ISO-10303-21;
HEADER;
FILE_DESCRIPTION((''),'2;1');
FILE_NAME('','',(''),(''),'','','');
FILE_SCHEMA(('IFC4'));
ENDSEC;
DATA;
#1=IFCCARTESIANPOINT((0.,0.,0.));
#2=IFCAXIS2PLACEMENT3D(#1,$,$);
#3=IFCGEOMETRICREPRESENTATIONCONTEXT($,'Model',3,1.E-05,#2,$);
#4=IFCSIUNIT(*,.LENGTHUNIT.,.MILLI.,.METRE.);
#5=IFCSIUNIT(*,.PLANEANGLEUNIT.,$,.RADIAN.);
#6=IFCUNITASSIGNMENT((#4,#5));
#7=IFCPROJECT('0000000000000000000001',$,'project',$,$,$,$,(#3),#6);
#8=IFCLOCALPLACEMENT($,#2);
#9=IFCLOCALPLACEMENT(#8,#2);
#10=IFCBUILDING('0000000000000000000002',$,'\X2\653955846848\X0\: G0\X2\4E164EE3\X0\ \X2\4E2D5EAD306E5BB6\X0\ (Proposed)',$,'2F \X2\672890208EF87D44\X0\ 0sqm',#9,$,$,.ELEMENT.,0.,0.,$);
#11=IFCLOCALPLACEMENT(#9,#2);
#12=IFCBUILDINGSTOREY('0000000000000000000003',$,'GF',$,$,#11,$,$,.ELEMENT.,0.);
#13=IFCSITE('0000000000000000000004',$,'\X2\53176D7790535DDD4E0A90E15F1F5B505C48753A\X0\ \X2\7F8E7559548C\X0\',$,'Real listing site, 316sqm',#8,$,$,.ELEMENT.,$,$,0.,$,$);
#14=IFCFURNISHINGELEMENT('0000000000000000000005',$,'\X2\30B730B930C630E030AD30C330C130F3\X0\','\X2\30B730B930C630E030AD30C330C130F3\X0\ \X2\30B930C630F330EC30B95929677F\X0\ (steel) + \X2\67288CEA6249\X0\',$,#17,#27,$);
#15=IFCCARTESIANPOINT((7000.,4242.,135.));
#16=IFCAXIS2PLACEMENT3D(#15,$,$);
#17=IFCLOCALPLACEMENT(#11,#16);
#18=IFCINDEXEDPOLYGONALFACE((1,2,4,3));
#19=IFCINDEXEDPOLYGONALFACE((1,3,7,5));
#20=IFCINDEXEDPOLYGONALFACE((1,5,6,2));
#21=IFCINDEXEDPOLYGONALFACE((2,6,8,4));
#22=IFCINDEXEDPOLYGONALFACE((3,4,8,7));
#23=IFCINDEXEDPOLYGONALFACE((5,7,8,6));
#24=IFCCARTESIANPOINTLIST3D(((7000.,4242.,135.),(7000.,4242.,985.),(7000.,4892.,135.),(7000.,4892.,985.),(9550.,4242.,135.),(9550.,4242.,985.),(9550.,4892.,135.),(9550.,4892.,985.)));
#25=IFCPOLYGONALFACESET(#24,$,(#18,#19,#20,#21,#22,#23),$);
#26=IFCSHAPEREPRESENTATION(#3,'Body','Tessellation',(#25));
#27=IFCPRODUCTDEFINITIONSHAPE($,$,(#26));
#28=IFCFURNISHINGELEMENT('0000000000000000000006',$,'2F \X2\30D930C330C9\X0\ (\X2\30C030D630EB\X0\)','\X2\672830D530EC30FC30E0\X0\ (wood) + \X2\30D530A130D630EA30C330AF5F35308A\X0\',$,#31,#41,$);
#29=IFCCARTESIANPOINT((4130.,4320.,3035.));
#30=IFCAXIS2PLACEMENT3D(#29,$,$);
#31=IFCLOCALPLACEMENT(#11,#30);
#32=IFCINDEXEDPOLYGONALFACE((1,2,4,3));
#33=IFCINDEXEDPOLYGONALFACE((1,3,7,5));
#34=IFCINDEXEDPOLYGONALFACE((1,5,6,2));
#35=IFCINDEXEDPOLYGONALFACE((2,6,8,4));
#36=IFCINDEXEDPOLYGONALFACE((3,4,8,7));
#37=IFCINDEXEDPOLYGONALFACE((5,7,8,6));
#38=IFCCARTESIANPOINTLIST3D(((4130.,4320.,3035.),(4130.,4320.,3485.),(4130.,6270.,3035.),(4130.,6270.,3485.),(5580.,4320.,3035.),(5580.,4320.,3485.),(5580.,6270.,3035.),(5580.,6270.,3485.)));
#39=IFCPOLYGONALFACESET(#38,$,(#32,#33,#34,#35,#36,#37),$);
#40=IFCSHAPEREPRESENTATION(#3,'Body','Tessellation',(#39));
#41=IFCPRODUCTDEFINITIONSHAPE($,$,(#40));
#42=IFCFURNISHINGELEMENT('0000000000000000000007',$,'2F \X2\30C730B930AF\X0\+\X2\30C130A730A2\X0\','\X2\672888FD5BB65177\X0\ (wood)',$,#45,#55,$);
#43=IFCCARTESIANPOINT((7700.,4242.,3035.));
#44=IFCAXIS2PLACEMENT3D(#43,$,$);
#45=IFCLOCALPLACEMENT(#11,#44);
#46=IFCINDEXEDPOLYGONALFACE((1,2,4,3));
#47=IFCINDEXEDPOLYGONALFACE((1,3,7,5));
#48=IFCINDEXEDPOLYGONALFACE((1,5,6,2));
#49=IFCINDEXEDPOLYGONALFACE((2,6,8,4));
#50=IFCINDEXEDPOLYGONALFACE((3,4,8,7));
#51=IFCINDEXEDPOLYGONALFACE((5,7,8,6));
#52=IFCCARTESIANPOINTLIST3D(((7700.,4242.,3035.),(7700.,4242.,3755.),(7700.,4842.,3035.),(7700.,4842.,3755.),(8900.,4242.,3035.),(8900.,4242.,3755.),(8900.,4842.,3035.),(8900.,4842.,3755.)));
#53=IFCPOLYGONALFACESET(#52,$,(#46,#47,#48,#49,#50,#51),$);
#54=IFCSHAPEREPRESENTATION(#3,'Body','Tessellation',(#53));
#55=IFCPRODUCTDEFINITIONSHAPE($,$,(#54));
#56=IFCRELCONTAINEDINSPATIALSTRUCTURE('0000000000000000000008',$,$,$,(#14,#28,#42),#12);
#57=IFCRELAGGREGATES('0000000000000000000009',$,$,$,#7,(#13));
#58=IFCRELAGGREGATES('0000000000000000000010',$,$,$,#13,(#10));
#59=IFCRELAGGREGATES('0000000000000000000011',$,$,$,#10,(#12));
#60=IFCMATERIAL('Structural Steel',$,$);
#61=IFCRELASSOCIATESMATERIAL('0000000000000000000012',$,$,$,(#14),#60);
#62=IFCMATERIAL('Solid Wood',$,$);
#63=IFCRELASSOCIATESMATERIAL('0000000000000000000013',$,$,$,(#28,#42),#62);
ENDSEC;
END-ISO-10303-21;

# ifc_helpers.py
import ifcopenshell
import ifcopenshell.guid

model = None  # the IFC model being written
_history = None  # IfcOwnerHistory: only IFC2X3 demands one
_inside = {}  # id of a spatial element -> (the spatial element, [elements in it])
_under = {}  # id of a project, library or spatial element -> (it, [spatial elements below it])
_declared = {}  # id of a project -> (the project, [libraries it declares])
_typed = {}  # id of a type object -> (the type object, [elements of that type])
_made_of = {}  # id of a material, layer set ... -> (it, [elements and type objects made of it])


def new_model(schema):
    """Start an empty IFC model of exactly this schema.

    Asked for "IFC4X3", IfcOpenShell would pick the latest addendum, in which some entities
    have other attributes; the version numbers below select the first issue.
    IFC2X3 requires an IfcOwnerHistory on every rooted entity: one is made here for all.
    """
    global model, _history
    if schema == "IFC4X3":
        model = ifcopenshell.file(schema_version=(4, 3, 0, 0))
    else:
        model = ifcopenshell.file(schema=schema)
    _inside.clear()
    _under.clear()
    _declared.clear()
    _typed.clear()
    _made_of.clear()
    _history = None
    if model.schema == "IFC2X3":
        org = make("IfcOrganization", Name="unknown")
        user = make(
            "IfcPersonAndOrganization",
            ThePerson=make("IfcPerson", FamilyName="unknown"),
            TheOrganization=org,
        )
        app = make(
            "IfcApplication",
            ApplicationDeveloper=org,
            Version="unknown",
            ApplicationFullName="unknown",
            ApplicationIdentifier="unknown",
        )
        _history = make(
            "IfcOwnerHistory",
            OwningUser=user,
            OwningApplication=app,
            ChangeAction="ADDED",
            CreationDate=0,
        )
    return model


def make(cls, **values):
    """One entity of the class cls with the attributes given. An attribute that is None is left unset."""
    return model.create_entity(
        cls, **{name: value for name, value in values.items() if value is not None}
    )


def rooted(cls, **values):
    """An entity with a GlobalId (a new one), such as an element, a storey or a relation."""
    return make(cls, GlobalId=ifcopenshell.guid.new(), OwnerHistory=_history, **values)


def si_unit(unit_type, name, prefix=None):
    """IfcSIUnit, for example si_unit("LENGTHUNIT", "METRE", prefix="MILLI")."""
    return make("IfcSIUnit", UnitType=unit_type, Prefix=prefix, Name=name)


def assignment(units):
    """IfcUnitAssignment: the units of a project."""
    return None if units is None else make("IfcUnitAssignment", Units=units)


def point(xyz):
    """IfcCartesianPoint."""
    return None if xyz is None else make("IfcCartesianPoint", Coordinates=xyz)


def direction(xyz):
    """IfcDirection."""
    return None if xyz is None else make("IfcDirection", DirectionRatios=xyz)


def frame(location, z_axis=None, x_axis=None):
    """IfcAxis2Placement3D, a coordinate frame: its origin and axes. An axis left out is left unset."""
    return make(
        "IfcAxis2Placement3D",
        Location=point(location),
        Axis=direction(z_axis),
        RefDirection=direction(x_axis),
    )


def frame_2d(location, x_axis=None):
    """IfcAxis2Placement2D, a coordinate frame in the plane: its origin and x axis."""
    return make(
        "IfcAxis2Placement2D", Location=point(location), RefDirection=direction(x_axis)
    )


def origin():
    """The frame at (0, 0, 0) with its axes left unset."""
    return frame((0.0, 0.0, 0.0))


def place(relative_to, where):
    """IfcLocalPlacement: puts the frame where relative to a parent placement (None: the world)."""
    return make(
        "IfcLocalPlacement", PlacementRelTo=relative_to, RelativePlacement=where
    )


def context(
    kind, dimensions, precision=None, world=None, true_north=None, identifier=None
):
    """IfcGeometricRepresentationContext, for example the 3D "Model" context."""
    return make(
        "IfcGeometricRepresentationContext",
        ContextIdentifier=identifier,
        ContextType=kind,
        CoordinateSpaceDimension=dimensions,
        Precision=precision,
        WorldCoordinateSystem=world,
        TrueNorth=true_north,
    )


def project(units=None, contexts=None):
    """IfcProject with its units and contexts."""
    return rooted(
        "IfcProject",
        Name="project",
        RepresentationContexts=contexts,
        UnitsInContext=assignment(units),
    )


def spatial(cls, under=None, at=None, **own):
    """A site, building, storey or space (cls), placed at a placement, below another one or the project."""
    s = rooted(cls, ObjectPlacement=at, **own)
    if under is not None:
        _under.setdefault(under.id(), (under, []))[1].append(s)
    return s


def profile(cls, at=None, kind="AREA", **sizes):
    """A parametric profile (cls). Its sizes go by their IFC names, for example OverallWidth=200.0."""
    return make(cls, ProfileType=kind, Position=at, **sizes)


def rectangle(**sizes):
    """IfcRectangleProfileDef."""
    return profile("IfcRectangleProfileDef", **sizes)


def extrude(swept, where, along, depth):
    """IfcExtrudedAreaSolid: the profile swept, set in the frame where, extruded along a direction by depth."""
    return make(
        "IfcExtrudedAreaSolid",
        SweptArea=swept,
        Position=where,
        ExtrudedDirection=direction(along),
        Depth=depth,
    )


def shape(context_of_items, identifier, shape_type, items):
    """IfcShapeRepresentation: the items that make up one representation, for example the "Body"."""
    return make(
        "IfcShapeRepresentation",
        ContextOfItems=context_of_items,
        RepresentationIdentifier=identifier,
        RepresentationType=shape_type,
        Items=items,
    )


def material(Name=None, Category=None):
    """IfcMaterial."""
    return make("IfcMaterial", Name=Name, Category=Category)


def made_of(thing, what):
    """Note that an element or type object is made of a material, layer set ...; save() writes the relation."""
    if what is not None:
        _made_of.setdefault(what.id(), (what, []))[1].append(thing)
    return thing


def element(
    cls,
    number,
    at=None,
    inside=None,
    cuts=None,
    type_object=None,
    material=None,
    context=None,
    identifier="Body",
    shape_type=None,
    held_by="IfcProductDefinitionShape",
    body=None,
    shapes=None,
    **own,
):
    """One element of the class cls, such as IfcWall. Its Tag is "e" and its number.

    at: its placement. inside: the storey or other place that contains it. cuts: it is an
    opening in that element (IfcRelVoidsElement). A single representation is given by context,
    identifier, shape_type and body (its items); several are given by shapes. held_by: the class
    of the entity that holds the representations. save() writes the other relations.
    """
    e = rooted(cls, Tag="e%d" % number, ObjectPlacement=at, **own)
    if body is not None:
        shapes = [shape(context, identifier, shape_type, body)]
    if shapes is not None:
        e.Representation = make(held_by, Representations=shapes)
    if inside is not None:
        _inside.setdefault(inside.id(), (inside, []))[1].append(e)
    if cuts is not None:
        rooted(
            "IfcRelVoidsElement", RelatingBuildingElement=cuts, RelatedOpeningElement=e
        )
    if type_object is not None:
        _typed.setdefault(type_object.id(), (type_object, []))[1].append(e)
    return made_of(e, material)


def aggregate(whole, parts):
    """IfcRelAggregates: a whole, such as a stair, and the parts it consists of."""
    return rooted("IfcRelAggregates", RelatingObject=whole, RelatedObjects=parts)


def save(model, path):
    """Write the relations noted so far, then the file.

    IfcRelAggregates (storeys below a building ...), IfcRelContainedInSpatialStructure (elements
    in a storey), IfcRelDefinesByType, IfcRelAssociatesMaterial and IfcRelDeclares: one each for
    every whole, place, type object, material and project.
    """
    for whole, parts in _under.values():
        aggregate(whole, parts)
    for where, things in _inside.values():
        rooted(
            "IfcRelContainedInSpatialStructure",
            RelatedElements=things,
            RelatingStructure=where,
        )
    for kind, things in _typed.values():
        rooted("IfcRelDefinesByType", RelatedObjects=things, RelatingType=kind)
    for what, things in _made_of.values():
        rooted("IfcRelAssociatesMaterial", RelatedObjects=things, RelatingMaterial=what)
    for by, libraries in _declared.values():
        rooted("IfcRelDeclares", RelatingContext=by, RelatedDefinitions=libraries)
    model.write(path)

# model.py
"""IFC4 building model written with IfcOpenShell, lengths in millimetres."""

from ifc_helpers import new_model, si_unit, frame, frame_2d, origin, place, context, project, spatial, rectangle, extrude, material, element, save


model = new_model("IFC4")

# Units and contexts
model_context = context("Model", 3, precision=1e-05, world=origin())
ifc_project = project(units=[si_unit("LENGTHUNIT", "METRE", prefix="MILLI"), si_unit("PLANEANGLEUNIT", "RADIAN")], contexts=[model_context])

# Site, building, storey
site_placement = place(None, origin())
site = spatial("IfcSite", under=ifc_project, at=site_placement, Name="北海道川上郡弟子屈町 美留和", ObjectType="Real listing site, 316sqm", CompositionType="ELEMENT", RefElevation=0.0)
building_placement = place(site_placement, origin())
building = spatial("IfcBuilding", under=site, at=building_placement, Name="改善案: G0世代 中庭の家 (Proposed)", ObjectType="2F 木造軸組 0sqm", CompositionType="ELEMENT", ElevationOfRefHeight=0.0, ElevationOfTerrain=0.0)
storey_placement = place(building_placement, origin())
storey = spatial("IfcBuildingStorey", under=building, at=storey_placement, Name="GF", CompositionType="ELEMENT", Elevation=0.0)

# Shared definitions
ifc_material_1 = material(Name="Solid Wood")

# Furnishing elements
ifc_material_2 = material(Name="Structural Steel")
furnishing_1_placement = place(storey_placement, frame((7000.0, 4242.0, 135.0)))
element("IfcFurnishingElement", 1, at=furnishing_1_placement, inside=storey, material=ifc_material_2, Name="システムキッチン", Description="システムキッチン ステンレス天板 (steel) + 木質扉", context=model_context, shape_type="SweptSolid", body=[
    extrude(rectangle(XDim=2550.0, YDim=650.0, at=frame_2d((1275.0, 325.0))), frame((7000.0, 4242.0, 135.0)), (0.0, 0.0, 1.0), 850.0),
])
furnishing_2_placement = place(storey_placement, frame((4130.0, 4320.0, 3035.0)))
element("IfcFurnishingElement", 2, at=furnishing_2_placement, inside=storey, material=ifc_material_1, Name="2F ベッド (ダブル)", Description="木フレーム (wood) + ファブリック張り", context=model_context, shape_type="SweptSolid", body=[
    extrude(rectangle(XDim=1450.0, YDim=1950.0, at=frame_2d((725.0, 975.0))), frame((4130.0, 4320.0, 3035.0)), (0.0, 0.0, 1.0), 450.0),
])
furnishing_3_placement = place(storey_placement, frame((7700.0, 4242.0, 3035.0)))
element("IfcFurnishingElement", 3, at=furnishing_3_placement, inside=storey, material=ifc_material_1, Name="2F デスク+チェア", Description="木製家具 (wood)", context=model_context, shape_type="SweptSolid", body=[
    extrude(rectangle(XDim=1200.0, YDim=600.0, at=frame_2d((600.0, 300.0))), frame((7700.0, 4242.0, 3035.0)), (0.0, 0.0, 1.0), 720.0),
])

save(model, "model.ifc")
